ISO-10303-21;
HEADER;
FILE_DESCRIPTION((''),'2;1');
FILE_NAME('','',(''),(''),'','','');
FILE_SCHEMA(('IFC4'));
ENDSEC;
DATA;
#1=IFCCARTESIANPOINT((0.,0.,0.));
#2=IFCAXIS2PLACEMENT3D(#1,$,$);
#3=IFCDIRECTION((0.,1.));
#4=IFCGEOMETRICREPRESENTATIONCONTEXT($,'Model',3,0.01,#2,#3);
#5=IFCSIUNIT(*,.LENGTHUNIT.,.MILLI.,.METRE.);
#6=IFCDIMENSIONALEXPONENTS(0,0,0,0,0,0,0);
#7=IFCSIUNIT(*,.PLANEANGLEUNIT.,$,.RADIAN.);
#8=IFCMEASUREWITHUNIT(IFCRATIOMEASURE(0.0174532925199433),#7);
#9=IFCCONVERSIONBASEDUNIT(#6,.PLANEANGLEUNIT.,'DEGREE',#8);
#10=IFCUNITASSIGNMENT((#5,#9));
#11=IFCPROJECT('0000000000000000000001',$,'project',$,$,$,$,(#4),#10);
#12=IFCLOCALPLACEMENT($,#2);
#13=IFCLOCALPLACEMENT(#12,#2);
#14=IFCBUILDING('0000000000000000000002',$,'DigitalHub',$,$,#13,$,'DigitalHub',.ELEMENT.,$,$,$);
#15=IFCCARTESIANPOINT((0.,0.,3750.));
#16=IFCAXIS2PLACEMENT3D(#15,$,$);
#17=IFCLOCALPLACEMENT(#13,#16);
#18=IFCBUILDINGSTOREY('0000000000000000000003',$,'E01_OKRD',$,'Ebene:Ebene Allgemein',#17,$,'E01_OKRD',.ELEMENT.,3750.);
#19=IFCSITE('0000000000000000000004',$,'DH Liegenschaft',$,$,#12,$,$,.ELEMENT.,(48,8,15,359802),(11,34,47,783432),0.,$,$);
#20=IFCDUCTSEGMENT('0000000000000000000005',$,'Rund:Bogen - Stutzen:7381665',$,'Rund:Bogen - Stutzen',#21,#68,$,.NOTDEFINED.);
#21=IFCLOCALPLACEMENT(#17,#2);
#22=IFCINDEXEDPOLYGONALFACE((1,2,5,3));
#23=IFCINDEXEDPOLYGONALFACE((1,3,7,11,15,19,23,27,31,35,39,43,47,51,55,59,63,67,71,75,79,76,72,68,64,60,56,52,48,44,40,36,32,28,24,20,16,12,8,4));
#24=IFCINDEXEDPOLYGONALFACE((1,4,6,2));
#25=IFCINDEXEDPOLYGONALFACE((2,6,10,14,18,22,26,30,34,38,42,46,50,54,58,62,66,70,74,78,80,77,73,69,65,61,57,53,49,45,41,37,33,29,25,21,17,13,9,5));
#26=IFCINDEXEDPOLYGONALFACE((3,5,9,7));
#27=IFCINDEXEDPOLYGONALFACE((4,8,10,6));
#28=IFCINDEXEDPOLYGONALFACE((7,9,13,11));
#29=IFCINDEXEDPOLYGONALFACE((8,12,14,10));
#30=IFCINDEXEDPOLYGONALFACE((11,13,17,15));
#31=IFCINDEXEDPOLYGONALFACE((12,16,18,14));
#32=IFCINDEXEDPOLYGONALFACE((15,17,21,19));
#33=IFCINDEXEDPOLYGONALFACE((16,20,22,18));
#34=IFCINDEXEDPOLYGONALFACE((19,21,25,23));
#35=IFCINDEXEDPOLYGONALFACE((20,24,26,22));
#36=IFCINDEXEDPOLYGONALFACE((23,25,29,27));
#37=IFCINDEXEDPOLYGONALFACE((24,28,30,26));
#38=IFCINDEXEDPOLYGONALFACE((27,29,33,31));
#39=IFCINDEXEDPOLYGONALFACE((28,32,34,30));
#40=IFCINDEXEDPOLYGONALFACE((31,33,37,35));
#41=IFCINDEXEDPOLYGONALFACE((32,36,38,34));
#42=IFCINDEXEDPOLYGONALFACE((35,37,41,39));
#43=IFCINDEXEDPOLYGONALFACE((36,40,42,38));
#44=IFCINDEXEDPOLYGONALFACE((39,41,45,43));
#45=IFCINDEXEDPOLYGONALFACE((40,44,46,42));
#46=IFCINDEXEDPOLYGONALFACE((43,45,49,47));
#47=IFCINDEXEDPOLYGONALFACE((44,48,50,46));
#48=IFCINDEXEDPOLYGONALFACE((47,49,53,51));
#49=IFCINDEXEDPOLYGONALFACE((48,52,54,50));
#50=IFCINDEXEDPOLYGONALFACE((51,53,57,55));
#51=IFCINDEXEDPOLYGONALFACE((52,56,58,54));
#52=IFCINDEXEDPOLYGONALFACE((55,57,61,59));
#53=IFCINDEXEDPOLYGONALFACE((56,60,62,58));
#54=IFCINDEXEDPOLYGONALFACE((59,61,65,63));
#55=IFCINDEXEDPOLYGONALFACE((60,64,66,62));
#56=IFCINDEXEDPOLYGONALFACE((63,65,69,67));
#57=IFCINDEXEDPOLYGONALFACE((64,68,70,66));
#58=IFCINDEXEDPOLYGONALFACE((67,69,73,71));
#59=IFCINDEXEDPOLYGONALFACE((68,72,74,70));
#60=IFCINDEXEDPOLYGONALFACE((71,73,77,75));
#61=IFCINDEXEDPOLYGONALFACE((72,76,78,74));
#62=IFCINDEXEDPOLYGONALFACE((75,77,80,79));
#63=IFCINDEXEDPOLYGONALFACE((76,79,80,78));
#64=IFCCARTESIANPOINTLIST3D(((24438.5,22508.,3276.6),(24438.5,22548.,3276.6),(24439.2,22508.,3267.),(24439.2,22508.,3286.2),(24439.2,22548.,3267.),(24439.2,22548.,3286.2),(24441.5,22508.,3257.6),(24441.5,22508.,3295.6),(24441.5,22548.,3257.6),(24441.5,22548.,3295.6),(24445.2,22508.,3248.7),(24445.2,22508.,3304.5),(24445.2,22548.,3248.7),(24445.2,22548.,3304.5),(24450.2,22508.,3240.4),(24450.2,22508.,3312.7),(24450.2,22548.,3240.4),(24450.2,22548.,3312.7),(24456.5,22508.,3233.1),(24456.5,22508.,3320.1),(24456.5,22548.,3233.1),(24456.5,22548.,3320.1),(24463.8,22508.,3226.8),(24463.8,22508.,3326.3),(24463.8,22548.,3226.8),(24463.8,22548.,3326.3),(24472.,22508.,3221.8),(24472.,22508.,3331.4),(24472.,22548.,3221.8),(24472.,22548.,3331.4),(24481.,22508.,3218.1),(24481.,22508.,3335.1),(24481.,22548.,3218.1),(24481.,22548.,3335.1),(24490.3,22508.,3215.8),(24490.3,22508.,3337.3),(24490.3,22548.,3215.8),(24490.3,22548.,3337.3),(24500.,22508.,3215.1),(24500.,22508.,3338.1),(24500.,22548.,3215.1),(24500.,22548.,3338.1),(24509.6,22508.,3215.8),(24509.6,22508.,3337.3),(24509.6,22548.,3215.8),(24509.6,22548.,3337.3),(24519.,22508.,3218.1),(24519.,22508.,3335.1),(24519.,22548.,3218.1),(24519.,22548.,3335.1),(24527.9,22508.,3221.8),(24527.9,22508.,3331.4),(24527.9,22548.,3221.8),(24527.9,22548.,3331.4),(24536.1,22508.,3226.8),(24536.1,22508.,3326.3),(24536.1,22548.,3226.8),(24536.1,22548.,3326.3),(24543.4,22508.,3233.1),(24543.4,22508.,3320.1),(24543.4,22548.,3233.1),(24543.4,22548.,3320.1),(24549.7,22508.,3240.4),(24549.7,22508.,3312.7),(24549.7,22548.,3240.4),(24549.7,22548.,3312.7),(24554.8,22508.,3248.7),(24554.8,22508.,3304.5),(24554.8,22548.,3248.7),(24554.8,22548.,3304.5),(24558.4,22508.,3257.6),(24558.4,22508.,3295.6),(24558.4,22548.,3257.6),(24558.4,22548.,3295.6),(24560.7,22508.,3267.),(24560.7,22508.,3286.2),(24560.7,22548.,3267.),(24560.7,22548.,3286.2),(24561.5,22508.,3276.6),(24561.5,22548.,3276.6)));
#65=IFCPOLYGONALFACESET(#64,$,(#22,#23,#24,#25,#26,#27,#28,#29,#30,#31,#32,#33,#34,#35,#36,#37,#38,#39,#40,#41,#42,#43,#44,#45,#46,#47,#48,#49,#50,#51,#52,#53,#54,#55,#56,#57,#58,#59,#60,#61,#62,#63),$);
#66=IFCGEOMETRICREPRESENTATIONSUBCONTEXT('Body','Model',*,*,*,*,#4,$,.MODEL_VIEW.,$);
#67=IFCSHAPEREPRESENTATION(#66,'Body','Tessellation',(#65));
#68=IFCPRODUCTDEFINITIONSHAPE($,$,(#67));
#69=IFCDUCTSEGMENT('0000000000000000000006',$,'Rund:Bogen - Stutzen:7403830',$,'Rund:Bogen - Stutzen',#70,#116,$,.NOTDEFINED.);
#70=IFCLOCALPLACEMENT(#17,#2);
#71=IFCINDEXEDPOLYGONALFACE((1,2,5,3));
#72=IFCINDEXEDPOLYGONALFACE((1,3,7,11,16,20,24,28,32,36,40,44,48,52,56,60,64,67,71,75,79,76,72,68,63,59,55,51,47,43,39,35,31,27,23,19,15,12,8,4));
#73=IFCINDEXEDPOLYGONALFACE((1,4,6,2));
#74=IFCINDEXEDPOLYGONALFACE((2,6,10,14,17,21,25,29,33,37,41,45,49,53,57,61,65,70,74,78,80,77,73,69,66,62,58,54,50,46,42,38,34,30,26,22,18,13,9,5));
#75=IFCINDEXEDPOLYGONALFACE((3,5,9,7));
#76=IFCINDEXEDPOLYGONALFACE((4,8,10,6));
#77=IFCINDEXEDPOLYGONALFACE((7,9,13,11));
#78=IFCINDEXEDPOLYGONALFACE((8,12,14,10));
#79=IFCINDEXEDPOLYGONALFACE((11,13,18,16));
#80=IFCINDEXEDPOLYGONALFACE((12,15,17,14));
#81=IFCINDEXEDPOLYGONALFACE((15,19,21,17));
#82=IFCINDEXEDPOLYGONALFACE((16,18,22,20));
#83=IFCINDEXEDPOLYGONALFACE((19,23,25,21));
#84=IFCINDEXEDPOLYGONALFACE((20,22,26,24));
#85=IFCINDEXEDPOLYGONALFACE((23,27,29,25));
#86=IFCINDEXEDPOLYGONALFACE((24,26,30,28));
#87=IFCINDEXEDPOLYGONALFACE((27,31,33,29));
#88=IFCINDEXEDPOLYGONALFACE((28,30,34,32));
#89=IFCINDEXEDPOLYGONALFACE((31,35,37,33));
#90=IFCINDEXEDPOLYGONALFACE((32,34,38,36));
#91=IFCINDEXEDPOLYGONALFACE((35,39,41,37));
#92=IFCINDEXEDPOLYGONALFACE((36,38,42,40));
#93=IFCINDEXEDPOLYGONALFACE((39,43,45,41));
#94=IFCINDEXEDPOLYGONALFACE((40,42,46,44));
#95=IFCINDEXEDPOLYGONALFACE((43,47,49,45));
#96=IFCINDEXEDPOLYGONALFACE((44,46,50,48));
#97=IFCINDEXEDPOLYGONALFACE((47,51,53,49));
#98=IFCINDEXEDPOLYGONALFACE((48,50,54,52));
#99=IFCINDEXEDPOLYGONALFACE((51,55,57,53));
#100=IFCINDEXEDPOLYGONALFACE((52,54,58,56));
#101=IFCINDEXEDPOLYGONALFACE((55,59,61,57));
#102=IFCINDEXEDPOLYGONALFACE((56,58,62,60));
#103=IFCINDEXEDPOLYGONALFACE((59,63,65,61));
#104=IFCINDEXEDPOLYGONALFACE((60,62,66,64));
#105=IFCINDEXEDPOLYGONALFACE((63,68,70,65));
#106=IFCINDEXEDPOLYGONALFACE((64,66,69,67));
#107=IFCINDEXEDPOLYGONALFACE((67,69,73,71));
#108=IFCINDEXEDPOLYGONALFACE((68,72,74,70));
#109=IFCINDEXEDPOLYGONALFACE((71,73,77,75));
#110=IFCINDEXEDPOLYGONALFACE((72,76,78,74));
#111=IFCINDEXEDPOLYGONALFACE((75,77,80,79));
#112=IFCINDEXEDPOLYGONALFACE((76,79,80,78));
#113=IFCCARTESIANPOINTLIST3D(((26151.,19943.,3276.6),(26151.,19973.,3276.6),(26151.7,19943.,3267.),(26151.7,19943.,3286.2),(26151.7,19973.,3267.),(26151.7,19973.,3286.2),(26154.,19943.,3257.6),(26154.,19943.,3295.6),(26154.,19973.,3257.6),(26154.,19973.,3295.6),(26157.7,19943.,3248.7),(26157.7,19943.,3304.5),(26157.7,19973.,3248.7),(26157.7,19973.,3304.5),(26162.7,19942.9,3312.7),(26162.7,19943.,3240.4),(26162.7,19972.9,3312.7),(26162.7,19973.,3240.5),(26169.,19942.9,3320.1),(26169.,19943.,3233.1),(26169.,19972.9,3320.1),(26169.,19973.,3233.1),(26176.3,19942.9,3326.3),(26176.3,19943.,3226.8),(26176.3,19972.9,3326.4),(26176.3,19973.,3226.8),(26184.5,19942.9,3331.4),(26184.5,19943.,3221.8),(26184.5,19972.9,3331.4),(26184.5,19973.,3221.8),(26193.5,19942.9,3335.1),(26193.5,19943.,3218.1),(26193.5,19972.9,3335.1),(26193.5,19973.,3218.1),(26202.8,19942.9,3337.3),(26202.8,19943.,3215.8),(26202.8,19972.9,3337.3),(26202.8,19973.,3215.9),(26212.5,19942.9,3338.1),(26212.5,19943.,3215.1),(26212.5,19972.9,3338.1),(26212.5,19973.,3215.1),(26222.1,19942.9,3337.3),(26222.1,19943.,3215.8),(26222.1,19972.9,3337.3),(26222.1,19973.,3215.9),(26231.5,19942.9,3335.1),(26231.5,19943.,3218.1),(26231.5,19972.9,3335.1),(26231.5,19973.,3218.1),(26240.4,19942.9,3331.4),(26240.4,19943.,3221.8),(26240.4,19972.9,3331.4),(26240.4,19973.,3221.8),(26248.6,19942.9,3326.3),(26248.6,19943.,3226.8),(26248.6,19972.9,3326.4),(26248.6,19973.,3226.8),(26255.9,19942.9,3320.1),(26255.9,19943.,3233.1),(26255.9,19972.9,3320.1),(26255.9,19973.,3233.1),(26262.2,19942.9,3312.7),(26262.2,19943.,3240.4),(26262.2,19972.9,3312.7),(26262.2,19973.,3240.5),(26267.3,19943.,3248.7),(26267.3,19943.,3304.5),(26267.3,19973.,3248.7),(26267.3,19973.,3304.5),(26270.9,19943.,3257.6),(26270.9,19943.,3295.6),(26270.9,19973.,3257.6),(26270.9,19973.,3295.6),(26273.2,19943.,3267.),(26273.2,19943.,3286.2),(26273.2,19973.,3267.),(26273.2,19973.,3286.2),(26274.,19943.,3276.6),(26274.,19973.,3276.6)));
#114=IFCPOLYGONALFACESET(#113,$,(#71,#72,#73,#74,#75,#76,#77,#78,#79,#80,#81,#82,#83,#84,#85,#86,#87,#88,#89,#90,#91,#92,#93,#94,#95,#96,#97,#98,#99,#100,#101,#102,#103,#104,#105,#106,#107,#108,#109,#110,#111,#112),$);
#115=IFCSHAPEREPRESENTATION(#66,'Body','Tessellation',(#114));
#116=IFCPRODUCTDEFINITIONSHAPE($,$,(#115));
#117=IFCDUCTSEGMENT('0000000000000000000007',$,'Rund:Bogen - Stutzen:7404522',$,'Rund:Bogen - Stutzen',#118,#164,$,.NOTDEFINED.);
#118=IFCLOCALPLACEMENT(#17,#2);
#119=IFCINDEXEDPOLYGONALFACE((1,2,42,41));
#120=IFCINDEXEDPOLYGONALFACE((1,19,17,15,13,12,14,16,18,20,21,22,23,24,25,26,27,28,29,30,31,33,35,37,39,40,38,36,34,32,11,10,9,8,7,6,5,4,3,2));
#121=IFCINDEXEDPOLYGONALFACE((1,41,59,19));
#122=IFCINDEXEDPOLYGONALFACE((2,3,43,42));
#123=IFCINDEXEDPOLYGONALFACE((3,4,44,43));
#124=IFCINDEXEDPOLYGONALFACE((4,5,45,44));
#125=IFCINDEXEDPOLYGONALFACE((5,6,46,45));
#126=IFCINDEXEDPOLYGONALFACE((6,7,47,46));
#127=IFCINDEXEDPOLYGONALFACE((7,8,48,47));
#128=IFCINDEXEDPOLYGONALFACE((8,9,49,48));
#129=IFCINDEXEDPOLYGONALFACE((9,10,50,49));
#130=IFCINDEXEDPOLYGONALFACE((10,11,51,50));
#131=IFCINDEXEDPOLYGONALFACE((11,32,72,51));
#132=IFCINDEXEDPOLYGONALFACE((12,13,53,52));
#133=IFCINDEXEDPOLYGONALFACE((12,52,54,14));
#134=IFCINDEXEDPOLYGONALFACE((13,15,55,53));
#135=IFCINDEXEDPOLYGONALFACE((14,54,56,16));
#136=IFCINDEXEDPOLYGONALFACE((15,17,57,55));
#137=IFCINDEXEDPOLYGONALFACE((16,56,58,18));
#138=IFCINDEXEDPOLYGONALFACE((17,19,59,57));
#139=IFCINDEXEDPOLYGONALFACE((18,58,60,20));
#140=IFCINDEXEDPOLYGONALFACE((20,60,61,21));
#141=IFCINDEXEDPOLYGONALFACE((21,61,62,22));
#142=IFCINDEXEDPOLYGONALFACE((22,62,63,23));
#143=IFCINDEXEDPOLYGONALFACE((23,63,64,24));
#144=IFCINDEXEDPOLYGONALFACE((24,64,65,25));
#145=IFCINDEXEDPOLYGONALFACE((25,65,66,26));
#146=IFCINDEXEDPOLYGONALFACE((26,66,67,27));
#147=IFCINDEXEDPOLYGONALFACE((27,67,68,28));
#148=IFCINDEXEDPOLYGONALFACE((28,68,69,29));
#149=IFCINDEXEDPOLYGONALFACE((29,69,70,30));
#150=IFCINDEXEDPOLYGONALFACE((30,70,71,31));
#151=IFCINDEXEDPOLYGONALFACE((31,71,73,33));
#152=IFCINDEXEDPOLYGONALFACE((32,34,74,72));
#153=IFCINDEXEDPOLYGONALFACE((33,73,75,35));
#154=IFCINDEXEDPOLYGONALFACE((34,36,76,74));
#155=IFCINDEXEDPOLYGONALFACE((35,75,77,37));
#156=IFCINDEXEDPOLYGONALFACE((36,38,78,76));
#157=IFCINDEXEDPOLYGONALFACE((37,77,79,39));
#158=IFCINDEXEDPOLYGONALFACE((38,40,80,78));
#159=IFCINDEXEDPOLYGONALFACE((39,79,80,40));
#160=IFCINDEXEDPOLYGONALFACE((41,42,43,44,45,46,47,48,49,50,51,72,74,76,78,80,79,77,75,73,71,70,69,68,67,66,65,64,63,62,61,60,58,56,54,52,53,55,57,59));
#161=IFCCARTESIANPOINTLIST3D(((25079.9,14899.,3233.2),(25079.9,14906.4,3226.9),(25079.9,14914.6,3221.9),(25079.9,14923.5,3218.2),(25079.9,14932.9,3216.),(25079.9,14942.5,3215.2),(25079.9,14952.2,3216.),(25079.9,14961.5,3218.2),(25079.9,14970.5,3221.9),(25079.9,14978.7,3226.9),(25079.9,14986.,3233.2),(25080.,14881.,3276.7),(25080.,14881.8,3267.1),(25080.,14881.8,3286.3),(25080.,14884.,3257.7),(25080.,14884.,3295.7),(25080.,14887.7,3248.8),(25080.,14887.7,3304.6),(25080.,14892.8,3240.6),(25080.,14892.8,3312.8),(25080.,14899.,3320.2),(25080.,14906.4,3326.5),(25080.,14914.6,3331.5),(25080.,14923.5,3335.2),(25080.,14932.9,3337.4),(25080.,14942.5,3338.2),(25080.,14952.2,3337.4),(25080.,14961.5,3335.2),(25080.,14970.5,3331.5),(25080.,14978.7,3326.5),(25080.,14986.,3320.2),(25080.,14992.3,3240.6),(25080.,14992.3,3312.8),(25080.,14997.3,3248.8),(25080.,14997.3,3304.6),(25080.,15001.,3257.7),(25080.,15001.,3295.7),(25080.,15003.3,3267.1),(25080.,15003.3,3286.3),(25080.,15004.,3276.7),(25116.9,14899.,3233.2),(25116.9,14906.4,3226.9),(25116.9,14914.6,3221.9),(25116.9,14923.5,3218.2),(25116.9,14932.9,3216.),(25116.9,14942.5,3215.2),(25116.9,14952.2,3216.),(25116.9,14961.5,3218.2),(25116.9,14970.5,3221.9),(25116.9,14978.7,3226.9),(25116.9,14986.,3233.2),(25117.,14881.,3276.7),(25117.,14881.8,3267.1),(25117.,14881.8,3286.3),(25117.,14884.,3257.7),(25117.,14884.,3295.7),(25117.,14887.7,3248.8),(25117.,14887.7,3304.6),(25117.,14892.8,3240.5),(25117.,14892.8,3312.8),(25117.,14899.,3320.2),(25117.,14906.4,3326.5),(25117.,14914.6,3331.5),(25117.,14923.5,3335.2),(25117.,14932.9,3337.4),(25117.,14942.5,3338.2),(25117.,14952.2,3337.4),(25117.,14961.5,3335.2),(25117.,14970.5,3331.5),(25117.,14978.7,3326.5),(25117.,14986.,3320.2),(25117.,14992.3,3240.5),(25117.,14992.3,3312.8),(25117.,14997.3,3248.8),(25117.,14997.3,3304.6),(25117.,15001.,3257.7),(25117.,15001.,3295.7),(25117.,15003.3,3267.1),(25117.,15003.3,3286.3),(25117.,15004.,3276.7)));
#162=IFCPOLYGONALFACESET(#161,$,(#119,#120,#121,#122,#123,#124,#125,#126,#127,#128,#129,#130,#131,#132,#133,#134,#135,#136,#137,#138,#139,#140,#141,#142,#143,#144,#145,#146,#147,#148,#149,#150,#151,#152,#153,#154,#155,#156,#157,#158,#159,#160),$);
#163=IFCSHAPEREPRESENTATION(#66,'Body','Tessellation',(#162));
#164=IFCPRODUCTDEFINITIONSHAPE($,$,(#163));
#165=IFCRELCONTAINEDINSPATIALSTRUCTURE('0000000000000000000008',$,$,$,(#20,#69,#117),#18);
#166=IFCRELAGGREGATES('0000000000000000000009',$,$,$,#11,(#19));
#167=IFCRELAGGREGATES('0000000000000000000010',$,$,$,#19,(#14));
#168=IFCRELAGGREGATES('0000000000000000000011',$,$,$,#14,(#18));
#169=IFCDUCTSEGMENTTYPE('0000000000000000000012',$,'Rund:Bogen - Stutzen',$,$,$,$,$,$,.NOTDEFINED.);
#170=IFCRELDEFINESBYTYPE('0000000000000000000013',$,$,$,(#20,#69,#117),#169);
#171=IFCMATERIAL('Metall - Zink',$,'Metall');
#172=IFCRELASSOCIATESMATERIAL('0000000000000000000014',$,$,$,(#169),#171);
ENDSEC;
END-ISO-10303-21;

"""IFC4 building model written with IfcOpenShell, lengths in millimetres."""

from ifc_helpers import new_model, entity, si_unit, converted_unit, direction, frame, origin, place, context, subcontext, project, spatial, indexed_curve, outline, extrude, material, type_object, element, save


model = new_model("IFC4")

# Units and contexts
model_context = context("Model", 3, precision=0.01, world=origin(), true_north=direction((0.0, 1.0)))
body_context = subcontext(model_context, "Body", "Model", "MODEL_VIEW")
ifc_project = project(units=[si_unit("LENGTHUNIT", "METRE", prefix="MILLI"), converted_unit("PLANEANGLEUNIT", "DEGREE", entity("IfcRatioMeasure", 0.0174532925199433), si_unit("PLANEANGLEUNIT", "RADIAN"), dimensions=[0, 0, 0, 0, 0, 0, 0])], contexts=[model_context])

# Site, building, storey
site_placement = place(None, origin())
site = spatial("IfcSite", under=ifc_project, at=site_placement, Name="DH Liegenschaft", CompositionType="ELEMENT", RefLatitude=(48, 8, 15, 359802), RefLongitude=(11, 34, 47, 783432), RefElevation=0.0)
building_placement = place(site_placement, origin())
building = spatial("IfcBuilding", under=site, at=building_placement, Name="DigitalHub", LongName="DigitalHub", CompositionType="ELEMENT")
storey_placement = place(building_placement, frame((0.0, 0.0, 3750.0)))
storey = spatial("IfcBuildingStorey", under=building, at=storey_placement, Name="E01_OKRD", ObjectType="Ebene:Ebene Allgemein", LongName="E01_OKRD", CompositionType="ELEMENT", Elevation=3750.0)

# Shared definitions
ifc_material_1 = material(Name="Metall - Zink", Category="Metall")

# Duct segments
duct_segment_type_1 = type_object("IfcDuctSegmentType", Name="Rund:Bogen - Stutzen", PredefinedType="NOTDEFINED", material=ifc_material_1)
duct_segment_1_placement = place(storey_placement, frame((24436.9, 22508.0, 3213.5)))
element("IfcDuctSegment", 1, at=duct_segment_1_placement, inside=storey, type_object=duct_segment_type_1, Name="Rund:Bogen - Stutzen:7381665", ObjectType="Rund:Bogen - Stutzen", PredefinedType="NOTDEFINED", context=body_context, shape_type="SweptSolid", body=[
    extrude(outline(indexed_curve([(61.5, 0.0), (60.7, 9.6), (58.5, 19.0), (54.8, 27.9), (49.8, 36.1), (43.5, 43.5), (36.1, 49.8), (27.9, 54.8), (19.0, 58.5), (9.6, 60.7), (0.0, 61.5), (-9.6, 60.7), (-19.0, 58.5), (-27.9, 54.8), (-36.1, 49.8), (-43.5, 43.5), (-49.8, 36.1), (-54.8, 27.9), (-58.5, 19.0), (-60.7, 9.6), (-61.5, 0.0), (-60.7, -9.6), (-58.5, -19.0), (-54.8, -27.9), (-49.8, -36.1), (-43.5, -43.5), (-36.1, -49.8), (-27.9, -54.8), (-19.0, -58.5), (-9.6, -60.7), (0.0, -61.5), (9.6, -60.7), (19.0, -58.5), (27.9, -54.8), (36.1, -49.8), (43.5, -43.5), (49.8, -36.1), (54.8, -27.9), (58.5, -19.0), (60.7, -9.6), (61.5, 0.0)], self_intersect=False)), frame((63.1, 0.0, 63.1), z_axis=(0.0, 1.0, 0.0), x_axis=(1.0, 0.0, 0.0)), (0.0, 0.0, 1.0), 40.0),
])
duct_segment_2_placement = place(storey_placement, frame((26149.4, 19942.9, 3213.5)))
element("IfcDuctSegment", 2, at=duct_segment_2_placement, inside=storey, type_object=duct_segment_type_1, Name="Rund:Bogen - Stutzen:7403830", ObjectType="Rund:Bogen - Stutzen", PredefinedType="NOTDEFINED", context=body_context, shape_type="SweptSolid", body=[
    extrude(outline(indexed_curve([(61.5, 0.0), (60.7, 9.6), (58.5, 19.0), (54.8, 27.9), (49.8, 36.1), (43.5, 43.5), (36.1, 49.8), (27.9, 54.8), (19.0, 58.5), (9.6, 60.7), (0.0, 61.5), (-9.6, 60.7), (-19.0, 58.5), (-27.9, 54.8), (-36.1, 49.8), (-43.5, 43.5), (-49.8, 36.1), (-54.8, 27.9), (-58.5, 19.0), (-60.7, 9.6), (-61.5, 0.0), (-60.7, -9.6), (-58.5, -19.0), (-54.8, -27.9), (-49.8, -36.1), (-43.5, -43.5), (-36.1, -49.8), (-27.9, -54.8), (-19.0, -58.5), (-9.6, -60.7), (0.0, -61.5), (9.6, -60.7), (19.0, -58.5), (27.9, -54.8), (36.1, -49.8), (43.5, -43.5), (49.8, -36.1), (54.8, -27.9), (58.5, -19.0), (60.7, -9.6), (61.5, 0.0)], self_intersect=False)), frame((63.1, 0.1, 63.1), z_axis=(0.0, 1.0, 0.000858), x_axis=(1.0, 0.0, 0.0)), (0.0, 0.0, 1.0), 30.0),
])
duct_segment_3_placement = place(storey_placement, frame((25079.9, 14879.4, 3213.6)))
element("IfcDuctSegment", 3, at=duct_segment_3_placement, inside=storey, type_object=duct_segment_type_1, Name="Rund:Bogen - Stutzen:7404522", ObjectType="Rund:Bogen - Stutzen", PredefinedType="NOTDEFINED", context=body_context, shape_type="SweptSolid", body=[
    extrude(outline(indexed_curve([(61.5, 0.0), (60.7, 9.6), (58.5, 19.0), (54.8, 27.9), (49.8, 36.1), (43.5, 43.5), (36.1, 49.8), (27.9, 54.8), (19.0, 58.5), (9.6, 60.7), (0.0, 61.5), (-9.6, 60.7), (-19.0, 58.5), (-27.9, 54.8), (-36.1, 49.8), (-43.5, 43.5), (-49.8, 36.1), (-54.8, 27.9), (-58.5, 19.0), (-60.7, 9.6), (-61.5, 0.0), (-60.7, -9.6), (-58.5, -19.0), (-54.8, -27.9), (-49.8, -36.1), (-43.5, -43.5), (-36.1, -49.8), (-27.9, -54.8), (-19.0, -58.5), (-9.6, -60.7), (0.0, -61.5), (9.6, -60.7), (19.0, -58.5), (27.9, -54.8), (36.1, -49.8), (43.5, -43.5), (49.8, -36.1), (54.8, -27.9), (58.5, -19.0), (60.7, -9.6), (61.5, 0.0)], self_intersect=False)), frame((37.0, 63.1, 63.1), z_axis=(-1.0, 0.0, 0.000116), x_axis=(0.0, 1.0, 0.0)), (0.0, 0.0, 1.0), 37.0),
])

save(model, "model.ifc")
